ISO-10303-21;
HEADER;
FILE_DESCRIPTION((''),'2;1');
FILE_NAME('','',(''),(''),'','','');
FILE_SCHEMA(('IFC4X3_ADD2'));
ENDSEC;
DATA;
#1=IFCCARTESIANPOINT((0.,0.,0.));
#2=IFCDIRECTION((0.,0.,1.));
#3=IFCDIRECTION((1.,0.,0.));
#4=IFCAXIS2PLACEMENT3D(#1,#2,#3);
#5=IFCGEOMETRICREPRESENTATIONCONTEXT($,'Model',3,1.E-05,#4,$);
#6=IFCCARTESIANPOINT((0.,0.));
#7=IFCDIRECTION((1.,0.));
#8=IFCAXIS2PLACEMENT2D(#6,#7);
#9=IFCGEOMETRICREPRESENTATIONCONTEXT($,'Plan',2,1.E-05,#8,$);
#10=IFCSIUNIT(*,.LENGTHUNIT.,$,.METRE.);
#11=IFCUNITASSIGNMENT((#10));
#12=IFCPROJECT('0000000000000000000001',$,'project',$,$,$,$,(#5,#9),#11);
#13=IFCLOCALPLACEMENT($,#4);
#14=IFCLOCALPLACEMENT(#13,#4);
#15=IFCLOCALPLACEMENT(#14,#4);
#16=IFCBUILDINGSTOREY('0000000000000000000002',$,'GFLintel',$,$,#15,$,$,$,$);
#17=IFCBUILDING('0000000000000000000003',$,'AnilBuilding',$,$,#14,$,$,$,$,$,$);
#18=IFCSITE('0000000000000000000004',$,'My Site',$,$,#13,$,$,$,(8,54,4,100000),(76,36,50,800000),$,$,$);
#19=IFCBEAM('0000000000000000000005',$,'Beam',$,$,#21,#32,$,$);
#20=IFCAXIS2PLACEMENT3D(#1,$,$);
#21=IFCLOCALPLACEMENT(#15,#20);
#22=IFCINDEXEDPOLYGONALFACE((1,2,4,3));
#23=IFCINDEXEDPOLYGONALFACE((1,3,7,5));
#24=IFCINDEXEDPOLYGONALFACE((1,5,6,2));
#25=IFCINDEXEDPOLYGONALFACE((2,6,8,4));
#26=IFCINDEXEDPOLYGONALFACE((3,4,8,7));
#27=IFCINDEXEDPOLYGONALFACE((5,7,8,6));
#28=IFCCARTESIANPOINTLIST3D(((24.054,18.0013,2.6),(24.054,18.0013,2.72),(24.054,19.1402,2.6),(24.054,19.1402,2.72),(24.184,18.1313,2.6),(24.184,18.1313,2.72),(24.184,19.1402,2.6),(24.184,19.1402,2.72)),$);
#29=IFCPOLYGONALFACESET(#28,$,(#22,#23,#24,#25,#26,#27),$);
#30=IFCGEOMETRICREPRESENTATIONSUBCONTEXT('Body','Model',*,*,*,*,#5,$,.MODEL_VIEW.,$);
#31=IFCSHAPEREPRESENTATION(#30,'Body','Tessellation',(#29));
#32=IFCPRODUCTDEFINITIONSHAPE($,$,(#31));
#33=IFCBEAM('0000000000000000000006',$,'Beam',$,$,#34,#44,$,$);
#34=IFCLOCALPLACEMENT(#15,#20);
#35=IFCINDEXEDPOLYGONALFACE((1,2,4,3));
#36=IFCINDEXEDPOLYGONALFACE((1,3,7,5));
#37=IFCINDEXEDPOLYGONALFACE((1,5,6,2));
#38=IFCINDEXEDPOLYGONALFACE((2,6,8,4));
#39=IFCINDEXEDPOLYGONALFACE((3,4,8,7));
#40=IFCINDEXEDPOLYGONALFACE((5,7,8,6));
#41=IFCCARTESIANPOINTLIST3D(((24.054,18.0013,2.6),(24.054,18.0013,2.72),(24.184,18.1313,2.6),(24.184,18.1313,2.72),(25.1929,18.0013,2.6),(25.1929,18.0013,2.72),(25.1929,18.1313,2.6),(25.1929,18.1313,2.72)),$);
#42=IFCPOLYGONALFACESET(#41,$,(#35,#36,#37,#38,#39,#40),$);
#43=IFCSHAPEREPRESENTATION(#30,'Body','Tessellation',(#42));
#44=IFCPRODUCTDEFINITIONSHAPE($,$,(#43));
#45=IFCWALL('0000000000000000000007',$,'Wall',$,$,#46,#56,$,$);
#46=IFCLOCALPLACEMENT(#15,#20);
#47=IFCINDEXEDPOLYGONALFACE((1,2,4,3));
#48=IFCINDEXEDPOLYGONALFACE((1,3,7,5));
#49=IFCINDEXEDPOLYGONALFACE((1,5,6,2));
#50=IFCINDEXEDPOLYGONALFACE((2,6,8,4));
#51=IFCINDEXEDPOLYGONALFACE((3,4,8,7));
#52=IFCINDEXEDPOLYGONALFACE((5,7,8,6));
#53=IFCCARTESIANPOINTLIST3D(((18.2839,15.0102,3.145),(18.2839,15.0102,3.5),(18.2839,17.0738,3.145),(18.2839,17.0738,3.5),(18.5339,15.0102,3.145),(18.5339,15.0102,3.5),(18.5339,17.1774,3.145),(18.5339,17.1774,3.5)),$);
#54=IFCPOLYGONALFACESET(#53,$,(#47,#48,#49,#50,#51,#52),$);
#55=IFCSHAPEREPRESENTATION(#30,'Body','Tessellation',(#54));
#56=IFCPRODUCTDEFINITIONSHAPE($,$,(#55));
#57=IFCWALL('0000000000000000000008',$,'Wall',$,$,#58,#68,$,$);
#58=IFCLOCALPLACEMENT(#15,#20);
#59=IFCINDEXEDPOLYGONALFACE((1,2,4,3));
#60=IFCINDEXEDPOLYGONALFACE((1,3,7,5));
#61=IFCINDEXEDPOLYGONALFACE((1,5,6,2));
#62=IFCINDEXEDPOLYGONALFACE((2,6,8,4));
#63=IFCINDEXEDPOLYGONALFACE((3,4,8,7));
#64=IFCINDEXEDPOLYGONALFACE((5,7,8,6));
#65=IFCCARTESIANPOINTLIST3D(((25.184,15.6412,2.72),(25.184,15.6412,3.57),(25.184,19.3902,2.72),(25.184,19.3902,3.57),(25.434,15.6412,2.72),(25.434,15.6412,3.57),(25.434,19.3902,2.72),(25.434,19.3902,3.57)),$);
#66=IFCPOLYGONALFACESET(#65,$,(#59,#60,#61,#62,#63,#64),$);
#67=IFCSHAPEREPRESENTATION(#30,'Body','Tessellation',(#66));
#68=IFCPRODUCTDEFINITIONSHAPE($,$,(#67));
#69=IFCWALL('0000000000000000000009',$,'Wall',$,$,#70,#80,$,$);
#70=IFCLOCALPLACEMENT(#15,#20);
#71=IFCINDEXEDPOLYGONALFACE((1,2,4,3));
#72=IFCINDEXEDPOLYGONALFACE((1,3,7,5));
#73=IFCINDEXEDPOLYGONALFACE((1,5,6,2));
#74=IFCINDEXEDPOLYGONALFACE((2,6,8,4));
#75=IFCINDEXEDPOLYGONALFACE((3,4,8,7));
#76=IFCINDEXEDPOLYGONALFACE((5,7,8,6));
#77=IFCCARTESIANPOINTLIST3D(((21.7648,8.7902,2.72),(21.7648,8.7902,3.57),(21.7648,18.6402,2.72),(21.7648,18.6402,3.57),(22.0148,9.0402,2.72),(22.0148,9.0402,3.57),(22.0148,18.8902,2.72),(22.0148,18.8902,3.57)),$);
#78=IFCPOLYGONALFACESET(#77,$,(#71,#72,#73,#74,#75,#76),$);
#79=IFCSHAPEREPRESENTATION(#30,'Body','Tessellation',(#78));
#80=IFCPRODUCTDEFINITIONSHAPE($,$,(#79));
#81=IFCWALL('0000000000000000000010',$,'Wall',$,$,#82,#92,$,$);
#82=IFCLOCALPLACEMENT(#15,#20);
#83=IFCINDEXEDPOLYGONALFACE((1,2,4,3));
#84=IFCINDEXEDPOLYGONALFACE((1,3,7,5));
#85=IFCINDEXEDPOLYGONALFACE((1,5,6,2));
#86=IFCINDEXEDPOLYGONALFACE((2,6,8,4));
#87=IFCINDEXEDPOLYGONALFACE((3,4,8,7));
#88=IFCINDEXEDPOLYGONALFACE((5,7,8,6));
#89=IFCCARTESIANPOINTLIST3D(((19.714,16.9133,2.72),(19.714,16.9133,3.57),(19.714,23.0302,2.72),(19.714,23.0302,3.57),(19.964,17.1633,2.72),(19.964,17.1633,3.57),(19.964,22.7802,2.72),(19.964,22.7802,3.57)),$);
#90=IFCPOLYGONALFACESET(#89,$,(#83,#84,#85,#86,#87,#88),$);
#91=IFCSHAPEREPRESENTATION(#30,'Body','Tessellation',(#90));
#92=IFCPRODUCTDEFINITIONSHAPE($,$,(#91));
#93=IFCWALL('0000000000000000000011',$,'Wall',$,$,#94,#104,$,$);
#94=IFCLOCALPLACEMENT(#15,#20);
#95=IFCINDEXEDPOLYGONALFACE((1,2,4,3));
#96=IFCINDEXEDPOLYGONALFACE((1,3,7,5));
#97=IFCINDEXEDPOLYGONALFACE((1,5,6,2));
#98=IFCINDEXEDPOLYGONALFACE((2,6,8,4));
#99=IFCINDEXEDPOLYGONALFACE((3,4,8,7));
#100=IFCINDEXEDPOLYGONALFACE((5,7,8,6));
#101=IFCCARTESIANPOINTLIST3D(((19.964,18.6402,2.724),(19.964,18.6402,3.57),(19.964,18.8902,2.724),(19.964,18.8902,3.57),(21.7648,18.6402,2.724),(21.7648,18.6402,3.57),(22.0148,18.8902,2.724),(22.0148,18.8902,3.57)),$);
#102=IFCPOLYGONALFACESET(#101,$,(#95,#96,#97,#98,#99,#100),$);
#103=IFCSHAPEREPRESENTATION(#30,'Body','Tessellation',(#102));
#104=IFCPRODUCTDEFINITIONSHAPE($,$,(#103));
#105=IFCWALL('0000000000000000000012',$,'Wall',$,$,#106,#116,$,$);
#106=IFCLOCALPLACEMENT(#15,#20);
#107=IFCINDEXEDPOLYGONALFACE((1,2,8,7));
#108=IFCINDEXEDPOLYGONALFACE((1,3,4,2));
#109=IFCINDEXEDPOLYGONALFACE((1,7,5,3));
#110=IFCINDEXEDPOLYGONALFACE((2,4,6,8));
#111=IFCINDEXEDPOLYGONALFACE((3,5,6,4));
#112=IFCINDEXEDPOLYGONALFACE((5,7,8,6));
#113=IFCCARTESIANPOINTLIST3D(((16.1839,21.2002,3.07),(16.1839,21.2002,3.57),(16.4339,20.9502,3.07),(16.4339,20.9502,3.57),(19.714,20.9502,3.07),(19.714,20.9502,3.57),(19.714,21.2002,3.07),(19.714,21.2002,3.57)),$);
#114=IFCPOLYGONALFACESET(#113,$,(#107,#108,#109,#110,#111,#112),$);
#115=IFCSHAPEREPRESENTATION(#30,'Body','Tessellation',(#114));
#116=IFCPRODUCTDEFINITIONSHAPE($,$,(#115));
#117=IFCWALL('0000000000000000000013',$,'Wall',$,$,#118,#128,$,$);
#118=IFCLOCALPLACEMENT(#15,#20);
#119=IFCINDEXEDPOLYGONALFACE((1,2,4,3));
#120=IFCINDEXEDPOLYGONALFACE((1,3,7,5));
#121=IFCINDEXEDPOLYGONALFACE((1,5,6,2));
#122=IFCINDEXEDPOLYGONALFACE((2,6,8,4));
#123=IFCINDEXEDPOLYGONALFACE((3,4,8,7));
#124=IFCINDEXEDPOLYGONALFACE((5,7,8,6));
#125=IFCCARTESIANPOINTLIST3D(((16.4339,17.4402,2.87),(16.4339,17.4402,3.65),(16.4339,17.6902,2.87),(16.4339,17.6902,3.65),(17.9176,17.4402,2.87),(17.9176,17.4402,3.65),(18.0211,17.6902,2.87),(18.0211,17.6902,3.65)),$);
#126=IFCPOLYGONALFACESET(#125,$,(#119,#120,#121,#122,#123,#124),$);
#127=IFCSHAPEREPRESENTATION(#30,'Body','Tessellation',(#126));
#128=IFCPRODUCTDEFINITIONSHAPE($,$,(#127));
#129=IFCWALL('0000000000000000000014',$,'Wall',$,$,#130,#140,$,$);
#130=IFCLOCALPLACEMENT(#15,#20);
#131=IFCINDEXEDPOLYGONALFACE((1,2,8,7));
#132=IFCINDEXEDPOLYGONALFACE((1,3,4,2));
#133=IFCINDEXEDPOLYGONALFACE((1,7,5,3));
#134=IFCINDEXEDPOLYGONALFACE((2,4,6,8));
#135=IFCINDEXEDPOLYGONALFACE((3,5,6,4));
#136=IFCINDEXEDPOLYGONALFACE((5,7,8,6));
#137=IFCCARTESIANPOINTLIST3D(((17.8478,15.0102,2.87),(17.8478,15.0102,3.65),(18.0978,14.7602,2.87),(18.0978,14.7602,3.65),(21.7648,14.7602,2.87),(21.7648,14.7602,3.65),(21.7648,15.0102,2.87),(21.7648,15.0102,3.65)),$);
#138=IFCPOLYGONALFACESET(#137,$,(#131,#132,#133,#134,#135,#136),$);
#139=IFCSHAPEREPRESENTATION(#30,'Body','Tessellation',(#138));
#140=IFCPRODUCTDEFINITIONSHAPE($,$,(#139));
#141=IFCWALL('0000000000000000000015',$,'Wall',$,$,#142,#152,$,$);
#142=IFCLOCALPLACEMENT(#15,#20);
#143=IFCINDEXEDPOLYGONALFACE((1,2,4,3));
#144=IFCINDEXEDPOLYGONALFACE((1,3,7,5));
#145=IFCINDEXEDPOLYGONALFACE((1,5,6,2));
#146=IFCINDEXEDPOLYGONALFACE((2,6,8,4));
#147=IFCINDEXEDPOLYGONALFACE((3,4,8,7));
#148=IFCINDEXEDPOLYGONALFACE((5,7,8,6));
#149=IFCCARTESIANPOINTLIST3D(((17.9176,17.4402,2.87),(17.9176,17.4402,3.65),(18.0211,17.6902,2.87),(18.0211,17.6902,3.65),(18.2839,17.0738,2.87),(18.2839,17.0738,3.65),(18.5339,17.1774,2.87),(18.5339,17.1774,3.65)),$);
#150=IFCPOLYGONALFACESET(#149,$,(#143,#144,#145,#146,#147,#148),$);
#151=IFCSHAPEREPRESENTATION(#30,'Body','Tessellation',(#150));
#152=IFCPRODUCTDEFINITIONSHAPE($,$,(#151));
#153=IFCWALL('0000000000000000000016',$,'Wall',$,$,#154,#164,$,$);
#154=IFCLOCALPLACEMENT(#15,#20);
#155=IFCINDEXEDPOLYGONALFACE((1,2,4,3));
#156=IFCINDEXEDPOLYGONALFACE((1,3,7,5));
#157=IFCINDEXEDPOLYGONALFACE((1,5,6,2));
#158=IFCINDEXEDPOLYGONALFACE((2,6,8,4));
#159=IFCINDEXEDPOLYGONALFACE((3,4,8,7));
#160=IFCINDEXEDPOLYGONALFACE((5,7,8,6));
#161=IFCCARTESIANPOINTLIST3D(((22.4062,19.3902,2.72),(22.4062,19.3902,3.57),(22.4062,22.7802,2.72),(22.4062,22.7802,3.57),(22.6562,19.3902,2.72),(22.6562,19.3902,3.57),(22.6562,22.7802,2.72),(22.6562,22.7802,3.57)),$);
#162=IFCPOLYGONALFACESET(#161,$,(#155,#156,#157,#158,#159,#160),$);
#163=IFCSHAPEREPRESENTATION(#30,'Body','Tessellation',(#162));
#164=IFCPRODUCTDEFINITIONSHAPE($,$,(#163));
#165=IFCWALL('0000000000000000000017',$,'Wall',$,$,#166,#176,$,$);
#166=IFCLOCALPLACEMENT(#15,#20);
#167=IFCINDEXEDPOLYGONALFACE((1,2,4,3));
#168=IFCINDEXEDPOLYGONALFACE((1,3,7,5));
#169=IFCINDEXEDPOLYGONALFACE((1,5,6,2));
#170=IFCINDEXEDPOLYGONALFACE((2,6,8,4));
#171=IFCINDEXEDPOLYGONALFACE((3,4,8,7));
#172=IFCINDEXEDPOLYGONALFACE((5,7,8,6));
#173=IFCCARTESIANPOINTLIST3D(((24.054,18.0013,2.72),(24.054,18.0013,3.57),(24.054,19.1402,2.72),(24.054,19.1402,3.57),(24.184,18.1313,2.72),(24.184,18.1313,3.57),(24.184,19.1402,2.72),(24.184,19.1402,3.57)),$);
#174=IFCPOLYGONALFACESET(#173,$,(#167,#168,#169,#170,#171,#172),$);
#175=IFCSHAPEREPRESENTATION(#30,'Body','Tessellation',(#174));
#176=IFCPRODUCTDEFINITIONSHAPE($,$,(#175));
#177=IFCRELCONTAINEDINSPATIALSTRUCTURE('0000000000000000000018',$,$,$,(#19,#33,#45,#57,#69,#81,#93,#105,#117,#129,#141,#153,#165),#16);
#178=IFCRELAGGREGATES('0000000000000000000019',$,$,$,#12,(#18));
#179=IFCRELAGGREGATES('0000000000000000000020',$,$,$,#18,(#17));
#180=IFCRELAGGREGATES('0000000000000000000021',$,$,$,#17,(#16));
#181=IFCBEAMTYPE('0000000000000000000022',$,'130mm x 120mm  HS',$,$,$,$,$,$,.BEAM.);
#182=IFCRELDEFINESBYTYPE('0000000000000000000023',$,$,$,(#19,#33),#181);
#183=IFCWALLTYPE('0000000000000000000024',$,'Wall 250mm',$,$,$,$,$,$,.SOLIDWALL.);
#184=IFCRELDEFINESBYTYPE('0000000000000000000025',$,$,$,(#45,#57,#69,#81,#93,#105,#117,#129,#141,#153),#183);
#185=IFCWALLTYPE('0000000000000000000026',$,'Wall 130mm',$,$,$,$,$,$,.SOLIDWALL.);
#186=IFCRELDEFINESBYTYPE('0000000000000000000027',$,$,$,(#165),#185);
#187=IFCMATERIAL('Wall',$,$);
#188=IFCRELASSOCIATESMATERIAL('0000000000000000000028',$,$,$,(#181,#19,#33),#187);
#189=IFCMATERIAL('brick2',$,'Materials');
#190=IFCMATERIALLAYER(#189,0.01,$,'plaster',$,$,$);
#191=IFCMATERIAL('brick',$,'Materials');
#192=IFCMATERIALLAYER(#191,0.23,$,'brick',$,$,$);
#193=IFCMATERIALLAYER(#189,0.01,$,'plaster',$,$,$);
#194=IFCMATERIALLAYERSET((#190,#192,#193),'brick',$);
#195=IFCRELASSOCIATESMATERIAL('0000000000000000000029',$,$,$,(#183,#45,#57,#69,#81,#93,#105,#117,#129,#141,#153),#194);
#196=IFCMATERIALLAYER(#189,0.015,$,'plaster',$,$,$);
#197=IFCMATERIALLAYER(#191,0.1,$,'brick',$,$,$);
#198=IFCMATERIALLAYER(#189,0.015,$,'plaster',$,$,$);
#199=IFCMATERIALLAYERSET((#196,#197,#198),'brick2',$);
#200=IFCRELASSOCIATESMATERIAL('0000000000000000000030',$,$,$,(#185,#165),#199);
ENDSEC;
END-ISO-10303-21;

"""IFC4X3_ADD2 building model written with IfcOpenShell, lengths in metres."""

from ifc_helpers import new_model, si_unit, frame, origin_with_axes, origin_2d_with_axis, place, context, subcontext, project, spatial, line, indexed_curve, rectangle, outline, extrude, clip, halfspace, material, layer, layer_set, layer_usage, material_profile, profile_set, profile_usage, type_object, element, save


model = new_model("IFC4X3_ADD2")

# Units and contexts
model_context = context("Model", 3, precision=1e-05, world=origin_with_axes())
plan_context = context("Plan", 2, precision=1e-05, world=origin_2d_with_axis())
body_context = subcontext(model_context, "Body", "Model", "MODEL_VIEW")
ifc_project = project(units=[si_unit("LENGTHUNIT", "METRE")], contexts=[model_context, plan_context])

# Site, building, storey
site_placement = place(None, origin_with_axes())
site = spatial("IfcSite", under=ifc_project, at=site_placement, Name="My Site", RefLatitude=(8, 54, 4, 100000), RefLongitude=(76, 36, 50, 800000))
building_placement = place(site_placement, origin_with_axes())
building = spatial("IfcBuilding", under=site, at=building_placement, Name="AnilBuilding")
storey_placement = place(building_placement, origin_with_axes())
storey = spatial("IfcBuildingStorey", under=building, at=storey_placement, Name="GFLintel")

# Beams
ifc_material_1 = material(Name="Wall")
ifc_material_profile_1 = material_profile(ifc_material_1, rectangle(XDim=0.13, YDim=0.12))
ifc_profile_set_1 = profile_set([ifc_material_profile_1], Name="concrete")
beam_type_1 = type_object("IfcBeamType", Name="130mm x 120mm  HS", PredefinedType="BEAM", material=ifc_profile_set_1)
ifc_profile_usage_1 = profile_usage(ifc_profile_set_1)
beam_1_placement = place(storey_placement, frame((24.119, 18.0013, 2.66), z_axis=(0.000001, 1.0, 0.0), x_axis=(-1.0, 0.000001, 0.0)))
element("IfcBeam", 1, at=beam_1_placement, inside=storey, type_object=beam_type_1, material=ifc_profile_usage_1, Name="Beam", context=body_context, shape_type="Clipping", body=[
    clip(extrude(rectangle(XDim=0.13, YDim=0.12), origin_with_axes(), (0.0, 0.0, 1.0), 1.1389), halfspace(frame((0.065, -2.66, 0.0), z_axis=(-0.707107, 0.0, -0.707106), x_axis=(0.0, 1.0, 0.0)), False)),
])
ifc_profile_usage_2 = profile_usage(ifc_profile_set_1)
beam_2_placement = place(storey_placement, frame((24.054, 18.0663, 2.66), z_axis=(1.0, -0.000001, 0.0), x_axis=(0.000001, 1.0, 0.0)))
element("IfcBeam", 2, at=beam_2_placement, inside=storey, type_object=beam_type_1, material=ifc_profile_usage_2, Name="Beam", context=body_context, shape_type="Clipping", body=[
    clip(extrude(rectangle(XDim=0.13, YDim=0.12), origin_with_axes(), (0.0, 0.0, 1.0), 1.1389), halfspace(frame((-0.065, -2.66, 0.0), z_axis=(0.707106, 0.0, -0.707107), x_axis=(0.000001, -1.0, 0.0)), False)),
])

# Walls
ifc_material_2 = material(Name="brick2", Category="Materials")
ifc_layer_1 = layer(ifc_material_2, 0.01, Name="plaster")
ifc_material_3 = material(Name="brick", Category="Materials")
ifc_layer_2 = layer(ifc_material_3, 0.23, Name="brick")
ifc_layer_3 = layer(ifc_material_2, 0.01, Name="plaster")
ifc_layer_set_1 = layer_set([ifc_layer_1, ifc_layer_2, ifc_layer_3], Name="brick")
ifc_layer_usage_1 = layer_usage(ifc_layer_set_1, "AXIS2", "NEGATIVE", 0.0)
wall_type_1 = type_object("IfcWallType", Name="Wall 250mm", PredefinedType="SOLIDWALL", material=ifc_layer_set_1)
wall_1_placement = place(storey_placement, frame((18.2839, 15.0102, 3.145), z_axis=(0.0, 0.0, 1.0), x_axis=(0.000001, 1.0, 0.0)))
element("IfcWall", 3, at=wall_1_placement, inside=storey, type_object=wall_type_1, material=ifc_layer_usage_1, Name="Wall", context=body_context, shape_type="SweptSolid", body=[
    extrude(outline(indexed_curve([(0.0, -0.25), (0.0, 0.0), (2.0636, 0.0), (2.1672, -0.25)], segments=[line(1, 2, 3, 4, 1)])), origin_with_axes(), (0.0, 0.0, 1.0), 0.355),
])
ifc_layer_usage_2 = layer_usage(ifc_layer_set_1, "AXIS2", "POSITIVE", 0.0)
wall_2_placement = place(storey_placement, frame((25.434, 15.6412, 2.72), z_axis=(0.0, 0.0, 1.0), x_axis=(0.000001, 1.0, 0.0)))
element("IfcWall", 4, at=wall_2_placement, inside=storey, type_object=wall_type_1, material=ifc_layer_usage_2, Name="Wall", context=body_context, shape_type="SweptSolid", body=[
    extrude(outline(indexed_curve([(0.0, 0.0), (0.0, 0.25), (3.749, 0.25), (3.749, 0.0)], segments=[line(1, 2, 3, 4, 1)])), origin_with_axes(), (0.0, 0.0, 1.0), 0.85),
])
ifc_layer_usage_3 = layer_usage(ifc_layer_set_1, "AXIS2", "NEGATIVE", 0.0)
wall_3_placement = place(storey_placement, frame((21.7648, 8.7902, 2.72), z_axis=(0.0, 0.0, 1.0), x_axis=(0.000001, 1.0, 0.0)))
element("IfcWall", 5, at=wall_3_placement, inside=storey, type_object=wall_type_1, material=ifc_layer_usage_3, Name="Wall", context=body_context, shape_type="SweptSolid", body=[
    extrude(outline(indexed_curve([(0.25, -0.25), (0.0, 0.0), (9.85, 0.0), (10.1, -0.25)], segments=[line(1, 2, 3, 4, 1)])), origin_with_axes(), (0.0, 0.0, 1.0), 0.85),
])
ifc_layer_usage_4 = layer_usage(ifc_layer_set_1, "AXIS2", "NEGATIVE", 0.0)
wall_4_placement = place(storey_placement, frame((19.714, 17.1633, 2.72), z_axis=(0.0, 0.0, 1.0), x_axis=(0.000001, 1.0, 0.0)))
element("IfcWall", 6, at=wall_4_placement, inside=storey, type_object=wall_type_1, material=ifc_layer_usage_4, Name="Wall", context=body_context, shape_type="SweptSolid", body=[
    extrude(outline(indexed_curve([(0.0, -0.25), (-0.25, 0.0), (5.8669, 0.0), (5.6169, -0.25)], segments=[line(1, 2, 3, 4, 1)])), origin_with_axes(), (0.0, 0.0, 1.0), 0.85),
])
ifc_layer_usage_5 = layer_usage(ifc_layer_set_1, "AXIS2", "POSITIVE", 0.0)
wall_5_placement = place(storey_placement, frame((19.714, 18.6402, 2.724), z_axis=(0.0, 0.0, 1.0), x_axis=(1.0, -0.000001, 0.0)))
element("IfcWall", 7, at=wall_5_placement, inside=storey, type_object=wall_type_1, material=ifc_layer_usage_5, Name="Wall", context=body_context, shape_type="SweptSolid", body=[
    extrude(outline(indexed_curve([(0.25, 0.0), (0.25, 0.25), (2.3008, 0.25), (2.0508, 0.0)], segments=[line(1, 2, 3, 4, 1)])), origin_with_axes(), (0.0, 0.0, 1.0), 0.846),
])
ifc_layer_usage_6 = layer_usage(ifc_layer_set_1, "AXIS2", "POSITIVE", 0.0)
wall_6_placement = place(storey_placement, frame((19.714, 21.2002, 3.07), z_axis=(0.0, 0.0, 1.0), x_axis=(-1.0, 0.0, 0.0)))
element("IfcWall", 8, at=wall_6_placement, inside=storey, type_object=wall_type_1, material=ifc_layer_usage_6, Name="Wall", context=body_context, shape_type="SweptSolid", body=[
    extrude(outline(indexed_curve([(0.0, 0.0), (0.0, 0.25), (3.28, 0.25), (3.53, 0.0)], segments=[line(1, 2, 3, 4, 1)])), origin_with_axes(), (0.0, 0.0, 1.0), 0.5),
])
ifc_layer_usage_7 = layer_usage(ifc_layer_set_1, "AXIS2", "NEGATIVE", 0.0)
wall_7_placement = place(storey_placement, frame((17.9176, 17.4402, 2.87), z_axis=(0.0, 0.0, 1.0), x_axis=(-1.0, 0.0, 0.0)))
element("IfcWall", 9, at=wall_7_placement, inside=storey, type_object=wall_type_1, material=ifc_layer_usage_7, Name="Wall", context=body_context, shape_type="SweptSolid", body=[
    extrude(outline(indexed_curve([(-0.1036, -0.25), (0.0, 0.0), (1.4836, 0.0), (1.4836, -0.25)], segments=[line(1, 2, 3, 4, 1)])), origin_with_axes(), (0.0, 0.0, 1.0), 0.78),
])
ifc_layer_usage_8 = layer_usage(ifc_layer_set_1, "AXIS2", "POSITIVE", 0.0)
wall_8_placement = place(storey_placement, frame((21.7648, 15.0102, 2.87), z_axis=(0.0, 0.0, 1.0), x_axis=(-1.0, 0.0, 0.0)))
element("IfcWall", 10, at=wall_8_placement, inside=storey, type_object=wall_type_1, material=ifc_layer_usage_8, Name="Wall", context=body_context, shape_type="SweptSolid", body=[
    extrude(outline(indexed_curve([(0.0, 0.0), (0.0, 0.25), (3.667, 0.25), (3.917, 0.0)], segments=[line(1, 2, 3, 4, 1)])), origin_with_axes(), (0.0, 0.0, 1.0), 0.78),
])
ifc_layer_usage_9 = layer_usage(ifc_layer_set_1, "AXIS2", "NEGATIVE", 0.0)
wall_9_placement = place(storey_placement, frame((18.2839, 17.0738, 2.87), z_axis=(0.0, 0.0, 1.0), x_axis=(-0.707107, 0.707107, 0.0)))
element("IfcWall", 11, at=wall_9_placement, inside=storey, type_object=wall_type_1, material=ifc_layer_usage_9, Name="Wall", context=body_context, shape_type="SweptSolid", body=[
    extrude(outline(indexed_curve([(-0.1036, -0.25), (0.0, 0.0), (0.5181, 0.0), (0.6217, -0.25)], segments=[line(1, 2, 3, 4, 1)])), origin_with_axes(), (0.0, 0.0, 1.0), 0.78),
])
ifc_layer_usage_10 = layer_usage(ifc_layer_set_1, "AXIS2", "POSITIVE", 0.0)
wall_10_placement = place(storey_placement, frame((22.6562, 19.3902, 2.72), z_axis=(0.0, 0.0, 1.0), x_axis=(0.000002, 1.0, 0.0)))
element("IfcWall", 12, at=wall_10_placement, inside=storey, type_object=wall_type_1, material=ifc_layer_usage_10, Name="Wall", context=body_context, shape_type="SweptSolid", body=[
    extrude(outline(indexed_curve([(0.0, 0.0), (0.0, 0.25), (3.39, 0.25), (3.39, 0.0)], segments=[line(1, 2, 3, 4, 1)])), origin_with_axes(), (0.0, 0.0, 1.0), 0.85),
])
ifc_layer_4 = layer(ifc_material_2, 0.015, Name="plaster")
ifc_layer_5 = layer(ifc_material_3, 0.1, Name="brick")
ifc_layer_6 = layer(ifc_material_2, 0.015, Name="plaster")
ifc_layer_set_2 = layer_set([ifc_layer_4, ifc_layer_5, ifc_layer_6], Name="brick2")
ifc_layer_usage_11 = layer_usage(ifc_layer_set_2, "AXIS2", "POSITIVE", 0.0)
wall_type_2 = type_object("IfcWallType", Name="Wall 130mm", PredefinedType="SOLIDWALL", material=ifc_layer_set_2)
wall_11_placement = place(storey_placement, frame((24.184, 18.1313, 2.72), z_axis=(0.0, 0.0, 1.0), x_axis=(0.000001, 1.0, 0.0)))
element("IfcWall", 13, at=wall_11_placement, inside=storey, type_object=wall_type_2, material=ifc_layer_usage_11, Name="Wall", context=body_context, shape_type="SweptSolid", body=[
    extrude(outline(indexed_curve([(0.0, 0.0), (-0.13, 0.13), (1.0089, 0.13), (1.0089, 0.0)], segments=[line(1, 2, 3, 4, 1)])), origin_with_axes(), (0.0, 0.0, 1.0), 0.85),
])

save(model, "model.ifc")
